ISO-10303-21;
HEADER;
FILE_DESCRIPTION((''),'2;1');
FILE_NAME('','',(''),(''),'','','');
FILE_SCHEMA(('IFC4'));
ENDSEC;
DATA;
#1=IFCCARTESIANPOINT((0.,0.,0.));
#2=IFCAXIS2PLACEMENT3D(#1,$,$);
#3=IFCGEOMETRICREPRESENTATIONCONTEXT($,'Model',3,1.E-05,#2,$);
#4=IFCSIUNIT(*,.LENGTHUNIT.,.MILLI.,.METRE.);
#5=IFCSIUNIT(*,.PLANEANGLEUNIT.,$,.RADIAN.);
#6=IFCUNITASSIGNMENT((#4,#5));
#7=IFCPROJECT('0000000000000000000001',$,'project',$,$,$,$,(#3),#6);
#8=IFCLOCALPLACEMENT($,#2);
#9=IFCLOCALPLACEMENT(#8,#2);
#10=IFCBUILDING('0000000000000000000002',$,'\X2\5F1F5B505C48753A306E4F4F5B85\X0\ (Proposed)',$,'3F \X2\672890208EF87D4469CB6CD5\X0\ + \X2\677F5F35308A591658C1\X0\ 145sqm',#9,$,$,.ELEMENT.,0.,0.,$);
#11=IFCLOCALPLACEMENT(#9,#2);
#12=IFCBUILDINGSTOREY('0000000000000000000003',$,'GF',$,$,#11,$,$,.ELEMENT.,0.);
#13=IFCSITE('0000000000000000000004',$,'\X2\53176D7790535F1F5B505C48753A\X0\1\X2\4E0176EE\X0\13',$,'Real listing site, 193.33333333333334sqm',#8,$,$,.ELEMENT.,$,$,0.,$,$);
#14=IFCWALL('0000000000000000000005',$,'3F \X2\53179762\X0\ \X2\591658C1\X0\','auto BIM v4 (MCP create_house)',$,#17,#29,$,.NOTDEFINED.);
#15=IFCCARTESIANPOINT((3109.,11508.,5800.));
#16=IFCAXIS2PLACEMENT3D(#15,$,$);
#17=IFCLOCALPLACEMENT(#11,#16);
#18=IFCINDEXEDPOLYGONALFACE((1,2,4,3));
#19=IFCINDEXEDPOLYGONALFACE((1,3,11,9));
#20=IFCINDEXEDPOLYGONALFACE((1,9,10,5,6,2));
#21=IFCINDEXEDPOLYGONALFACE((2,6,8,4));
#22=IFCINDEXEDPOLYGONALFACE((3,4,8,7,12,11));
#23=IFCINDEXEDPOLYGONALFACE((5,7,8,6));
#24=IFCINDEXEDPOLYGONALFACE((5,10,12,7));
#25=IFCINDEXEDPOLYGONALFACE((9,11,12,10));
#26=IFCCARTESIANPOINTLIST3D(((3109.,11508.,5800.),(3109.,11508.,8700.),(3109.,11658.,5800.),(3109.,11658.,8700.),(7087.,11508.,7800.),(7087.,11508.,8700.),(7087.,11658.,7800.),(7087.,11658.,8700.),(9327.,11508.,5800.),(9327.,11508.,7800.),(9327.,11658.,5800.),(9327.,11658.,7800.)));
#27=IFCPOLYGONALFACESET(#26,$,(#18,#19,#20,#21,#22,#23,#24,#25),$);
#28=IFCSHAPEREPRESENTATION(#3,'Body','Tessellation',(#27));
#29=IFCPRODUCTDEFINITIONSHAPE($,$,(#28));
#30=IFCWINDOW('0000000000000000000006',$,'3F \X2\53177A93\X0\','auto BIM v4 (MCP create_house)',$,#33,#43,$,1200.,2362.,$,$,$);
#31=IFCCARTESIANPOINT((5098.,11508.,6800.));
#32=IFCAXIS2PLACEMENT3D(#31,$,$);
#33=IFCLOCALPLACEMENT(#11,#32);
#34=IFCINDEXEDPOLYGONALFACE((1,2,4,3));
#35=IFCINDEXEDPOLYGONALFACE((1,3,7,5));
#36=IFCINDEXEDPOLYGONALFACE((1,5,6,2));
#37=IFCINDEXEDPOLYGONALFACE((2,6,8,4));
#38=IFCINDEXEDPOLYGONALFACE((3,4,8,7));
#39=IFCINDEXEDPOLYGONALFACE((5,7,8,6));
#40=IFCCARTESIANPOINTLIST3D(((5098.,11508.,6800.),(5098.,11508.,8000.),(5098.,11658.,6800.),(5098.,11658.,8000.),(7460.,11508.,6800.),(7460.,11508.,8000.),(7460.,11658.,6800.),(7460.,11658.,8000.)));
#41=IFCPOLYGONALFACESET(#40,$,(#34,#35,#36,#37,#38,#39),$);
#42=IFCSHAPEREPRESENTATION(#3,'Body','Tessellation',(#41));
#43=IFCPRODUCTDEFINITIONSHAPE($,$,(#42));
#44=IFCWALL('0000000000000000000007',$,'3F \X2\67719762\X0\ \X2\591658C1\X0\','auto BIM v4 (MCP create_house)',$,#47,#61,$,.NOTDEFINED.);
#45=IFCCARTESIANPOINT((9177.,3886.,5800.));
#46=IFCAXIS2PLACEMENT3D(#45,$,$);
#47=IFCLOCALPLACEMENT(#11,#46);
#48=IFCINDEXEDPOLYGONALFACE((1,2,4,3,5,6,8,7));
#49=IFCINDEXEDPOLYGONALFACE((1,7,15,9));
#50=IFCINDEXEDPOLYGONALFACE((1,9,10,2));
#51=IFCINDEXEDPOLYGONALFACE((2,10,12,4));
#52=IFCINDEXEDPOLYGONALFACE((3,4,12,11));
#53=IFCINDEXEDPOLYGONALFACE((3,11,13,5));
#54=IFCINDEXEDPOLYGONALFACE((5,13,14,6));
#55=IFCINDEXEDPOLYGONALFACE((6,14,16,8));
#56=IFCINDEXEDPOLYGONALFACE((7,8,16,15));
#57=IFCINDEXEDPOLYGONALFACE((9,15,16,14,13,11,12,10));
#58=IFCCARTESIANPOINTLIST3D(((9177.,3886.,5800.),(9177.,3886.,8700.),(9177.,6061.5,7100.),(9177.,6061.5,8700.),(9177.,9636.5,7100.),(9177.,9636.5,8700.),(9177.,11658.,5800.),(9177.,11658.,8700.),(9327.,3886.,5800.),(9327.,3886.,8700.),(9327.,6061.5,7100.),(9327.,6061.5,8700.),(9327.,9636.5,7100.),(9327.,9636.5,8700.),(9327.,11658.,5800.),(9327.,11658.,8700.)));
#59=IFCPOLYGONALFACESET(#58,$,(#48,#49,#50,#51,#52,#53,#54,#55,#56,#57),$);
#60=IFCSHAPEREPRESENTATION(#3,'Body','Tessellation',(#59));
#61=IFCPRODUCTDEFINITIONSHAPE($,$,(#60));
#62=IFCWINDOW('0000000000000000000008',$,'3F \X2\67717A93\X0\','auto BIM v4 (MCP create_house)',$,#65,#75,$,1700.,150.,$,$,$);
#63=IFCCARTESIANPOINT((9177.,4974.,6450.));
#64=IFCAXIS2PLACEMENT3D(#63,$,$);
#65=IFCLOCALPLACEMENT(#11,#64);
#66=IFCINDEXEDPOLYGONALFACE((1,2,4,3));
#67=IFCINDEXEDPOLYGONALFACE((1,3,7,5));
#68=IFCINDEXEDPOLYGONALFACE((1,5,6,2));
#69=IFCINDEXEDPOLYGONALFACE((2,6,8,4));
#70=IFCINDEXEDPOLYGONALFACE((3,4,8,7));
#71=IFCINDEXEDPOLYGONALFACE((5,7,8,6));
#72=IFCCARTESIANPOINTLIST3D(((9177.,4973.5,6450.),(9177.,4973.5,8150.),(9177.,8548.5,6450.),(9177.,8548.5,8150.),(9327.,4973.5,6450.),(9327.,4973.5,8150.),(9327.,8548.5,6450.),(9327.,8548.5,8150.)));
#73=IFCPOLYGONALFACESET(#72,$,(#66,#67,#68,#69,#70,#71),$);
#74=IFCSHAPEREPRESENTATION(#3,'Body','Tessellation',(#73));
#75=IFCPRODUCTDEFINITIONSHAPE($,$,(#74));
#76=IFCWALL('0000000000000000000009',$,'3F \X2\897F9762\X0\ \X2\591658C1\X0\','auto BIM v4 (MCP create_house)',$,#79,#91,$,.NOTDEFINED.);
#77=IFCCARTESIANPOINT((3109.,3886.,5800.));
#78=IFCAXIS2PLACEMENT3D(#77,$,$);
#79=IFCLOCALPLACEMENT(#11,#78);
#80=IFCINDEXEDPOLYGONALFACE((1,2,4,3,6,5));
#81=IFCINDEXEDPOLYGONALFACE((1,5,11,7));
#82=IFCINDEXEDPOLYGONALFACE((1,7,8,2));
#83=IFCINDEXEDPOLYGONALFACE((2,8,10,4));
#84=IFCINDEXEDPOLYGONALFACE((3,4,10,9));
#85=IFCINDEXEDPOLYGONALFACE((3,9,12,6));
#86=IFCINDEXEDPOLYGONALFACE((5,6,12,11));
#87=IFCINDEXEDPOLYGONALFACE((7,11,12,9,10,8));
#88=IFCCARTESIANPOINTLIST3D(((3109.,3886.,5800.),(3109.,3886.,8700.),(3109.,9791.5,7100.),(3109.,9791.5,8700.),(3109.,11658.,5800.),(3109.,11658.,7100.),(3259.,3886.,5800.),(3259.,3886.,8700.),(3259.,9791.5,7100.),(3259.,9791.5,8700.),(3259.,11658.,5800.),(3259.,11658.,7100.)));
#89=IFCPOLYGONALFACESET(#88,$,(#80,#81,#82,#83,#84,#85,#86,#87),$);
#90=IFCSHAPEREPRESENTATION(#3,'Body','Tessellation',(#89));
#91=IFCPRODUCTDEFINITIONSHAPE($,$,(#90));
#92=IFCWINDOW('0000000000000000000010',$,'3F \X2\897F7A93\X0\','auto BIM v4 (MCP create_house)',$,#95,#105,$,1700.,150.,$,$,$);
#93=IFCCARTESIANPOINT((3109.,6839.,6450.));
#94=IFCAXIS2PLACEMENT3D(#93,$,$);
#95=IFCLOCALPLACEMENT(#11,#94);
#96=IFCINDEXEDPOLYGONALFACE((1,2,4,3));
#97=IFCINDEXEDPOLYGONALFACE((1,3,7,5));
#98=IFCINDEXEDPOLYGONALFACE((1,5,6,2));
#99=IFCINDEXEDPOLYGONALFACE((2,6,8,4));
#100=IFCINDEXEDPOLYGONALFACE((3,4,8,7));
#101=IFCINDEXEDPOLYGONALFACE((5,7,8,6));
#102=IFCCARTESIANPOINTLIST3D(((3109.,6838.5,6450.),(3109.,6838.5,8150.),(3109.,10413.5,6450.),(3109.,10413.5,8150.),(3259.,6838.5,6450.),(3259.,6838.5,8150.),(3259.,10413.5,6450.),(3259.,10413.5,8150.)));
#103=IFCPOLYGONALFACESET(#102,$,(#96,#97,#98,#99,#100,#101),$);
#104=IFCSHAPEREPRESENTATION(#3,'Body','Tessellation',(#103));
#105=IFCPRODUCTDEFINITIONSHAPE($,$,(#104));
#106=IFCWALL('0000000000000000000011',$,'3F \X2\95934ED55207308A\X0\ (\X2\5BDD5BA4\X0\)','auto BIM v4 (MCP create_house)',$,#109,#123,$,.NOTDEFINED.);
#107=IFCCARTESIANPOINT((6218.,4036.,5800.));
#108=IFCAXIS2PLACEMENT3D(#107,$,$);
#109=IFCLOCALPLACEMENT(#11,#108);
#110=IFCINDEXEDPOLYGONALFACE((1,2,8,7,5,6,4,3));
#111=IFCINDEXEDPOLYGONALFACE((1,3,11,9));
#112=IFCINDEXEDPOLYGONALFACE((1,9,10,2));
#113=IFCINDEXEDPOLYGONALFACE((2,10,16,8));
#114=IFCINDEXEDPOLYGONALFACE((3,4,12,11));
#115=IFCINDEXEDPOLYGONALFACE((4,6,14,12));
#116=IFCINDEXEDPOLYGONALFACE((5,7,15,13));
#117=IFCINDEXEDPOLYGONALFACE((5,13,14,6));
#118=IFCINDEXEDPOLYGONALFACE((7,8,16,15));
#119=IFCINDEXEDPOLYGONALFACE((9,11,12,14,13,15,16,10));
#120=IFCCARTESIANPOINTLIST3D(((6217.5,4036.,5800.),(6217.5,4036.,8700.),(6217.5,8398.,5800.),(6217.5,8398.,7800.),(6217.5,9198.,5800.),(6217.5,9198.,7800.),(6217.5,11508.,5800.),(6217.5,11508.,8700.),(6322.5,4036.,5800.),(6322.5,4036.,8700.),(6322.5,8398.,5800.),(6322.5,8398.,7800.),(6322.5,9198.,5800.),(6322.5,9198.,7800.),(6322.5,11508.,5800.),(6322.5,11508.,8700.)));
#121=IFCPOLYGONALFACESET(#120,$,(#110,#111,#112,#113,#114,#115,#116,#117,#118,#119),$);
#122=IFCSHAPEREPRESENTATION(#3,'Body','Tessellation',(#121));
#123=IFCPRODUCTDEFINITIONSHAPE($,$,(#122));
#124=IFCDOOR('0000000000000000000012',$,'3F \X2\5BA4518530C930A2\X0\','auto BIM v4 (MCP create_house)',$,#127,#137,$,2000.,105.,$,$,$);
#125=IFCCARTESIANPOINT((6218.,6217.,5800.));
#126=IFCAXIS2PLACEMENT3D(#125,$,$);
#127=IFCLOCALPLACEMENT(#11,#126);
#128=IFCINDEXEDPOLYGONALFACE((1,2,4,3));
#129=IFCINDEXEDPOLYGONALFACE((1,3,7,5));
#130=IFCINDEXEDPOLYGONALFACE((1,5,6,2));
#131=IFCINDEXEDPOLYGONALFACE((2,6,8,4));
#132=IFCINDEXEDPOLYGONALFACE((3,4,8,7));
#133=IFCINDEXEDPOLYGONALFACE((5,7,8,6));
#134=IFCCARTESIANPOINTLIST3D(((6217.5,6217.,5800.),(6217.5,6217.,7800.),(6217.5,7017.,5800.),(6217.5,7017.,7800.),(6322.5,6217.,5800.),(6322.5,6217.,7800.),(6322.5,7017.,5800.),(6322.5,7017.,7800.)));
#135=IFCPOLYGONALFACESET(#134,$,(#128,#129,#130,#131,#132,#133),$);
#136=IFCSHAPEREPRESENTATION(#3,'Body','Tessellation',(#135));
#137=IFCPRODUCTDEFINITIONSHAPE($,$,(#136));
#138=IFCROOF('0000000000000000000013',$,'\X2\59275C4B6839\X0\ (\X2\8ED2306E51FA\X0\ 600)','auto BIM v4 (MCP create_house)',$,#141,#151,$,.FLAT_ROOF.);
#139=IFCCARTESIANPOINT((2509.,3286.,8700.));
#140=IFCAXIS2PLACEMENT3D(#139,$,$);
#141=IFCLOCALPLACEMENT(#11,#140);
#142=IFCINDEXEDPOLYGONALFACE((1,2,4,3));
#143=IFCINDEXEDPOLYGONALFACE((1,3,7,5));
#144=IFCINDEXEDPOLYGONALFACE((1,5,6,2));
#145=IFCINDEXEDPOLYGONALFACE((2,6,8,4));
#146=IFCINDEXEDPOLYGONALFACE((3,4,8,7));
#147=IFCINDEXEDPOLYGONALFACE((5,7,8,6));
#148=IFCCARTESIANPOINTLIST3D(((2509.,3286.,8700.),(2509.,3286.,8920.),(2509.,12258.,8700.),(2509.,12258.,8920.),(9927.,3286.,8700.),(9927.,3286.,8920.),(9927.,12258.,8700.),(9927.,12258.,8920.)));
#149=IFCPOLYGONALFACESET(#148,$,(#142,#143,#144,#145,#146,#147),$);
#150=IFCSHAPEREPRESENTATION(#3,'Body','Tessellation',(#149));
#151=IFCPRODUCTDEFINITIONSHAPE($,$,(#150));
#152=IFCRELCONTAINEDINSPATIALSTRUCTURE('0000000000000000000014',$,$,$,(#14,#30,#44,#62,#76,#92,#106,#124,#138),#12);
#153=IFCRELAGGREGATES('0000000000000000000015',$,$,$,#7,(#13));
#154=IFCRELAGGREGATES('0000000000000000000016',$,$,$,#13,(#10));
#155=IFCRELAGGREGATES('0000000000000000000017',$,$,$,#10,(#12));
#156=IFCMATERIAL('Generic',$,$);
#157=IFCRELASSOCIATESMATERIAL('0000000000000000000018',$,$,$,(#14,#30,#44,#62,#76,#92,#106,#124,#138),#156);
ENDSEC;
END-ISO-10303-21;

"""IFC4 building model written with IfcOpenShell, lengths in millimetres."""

from ifc_helpers import new_model, si_unit, frame, frame_2d, origin, place, context, project, spatial, rectangle, extrude, material, element, fill, save


model = new_model("IFC4")

# Units and contexts
model_context = context("Model", 3, precision=1e-05, world=origin())
ifc_project = project(units=[si_unit("LENGTHUNIT", "METRE", prefix="MILLI"), si_unit("PLANEANGLEUNIT", "RADIAN")], contexts=[model_context])

# Site, building, storey
site_placement = place(None, origin())
site = spatial("IfcSite", under=ifc_project, at=site_placement, Name="北海道弟子屈町1丁目13", ObjectType="Real listing site, 193.33333333333334sqm", CompositionType="ELEMENT", RefElevation=0.0)
building_placement = place(site_placement, origin())
building = spatial("IfcBuilding", under=site, at=building_placement, Name="弟子屈町の住宅 (Proposed)", ObjectType="3F 木造軸組構法 + 板張り外壁 145sqm", CompositionType="ELEMENT", ElevationOfRefHeight=0.0, ElevationOfTerrain=0.0)
storey_placement = place(building_placement, origin())
storey = spatial("IfcBuildingStorey", under=building, at=storey_placement, Name="GF", CompositionType="ELEMENT", Elevation=0.0)

# Shared definitions
ifc_material = material(Name="Generic")

# Walls, openings, windows
wall_1_placement = place(storey_placement, frame((3109.0, 11508.0, 5800.0)))
wall_1 = element("IfcWall", 1, at=wall_1_placement, inside=storey, material=ifc_material, Name="3F 北面 外壁", Description="auto BIM v4 (MCP create_house)", PredefinedType="NOTDEFINED", context=model_context, shape_type="SweptSolid", body=[
    extrude(rectangle(XDim=6218.0, YDim=150.0, at=frame_2d((3109.0, 75.0))), frame((3109.0, 11508.0, 5800.0)), (0.0, 0.0, 1.0), 2900.0),
])
opening_1_placement = place(storey_placement, frame((5098.0, 11508.0, 6800.0)))
opening_1 = element("IfcOpeningElement", 2, at=opening_1_placement, cuts=wall_1, PredefinedType="NOTDEFINED", context=model_context, shape_type="SweptSolid", body=[
    extrude(rectangle(XDim=2362.0, YDim=150.0, at=frame_2d((1181.0, 75.0))), frame((5098.0, 11508.0, 6800.0)), (0.0, 0.0, 1.0), 1200.0),
])
window_1_placement = place(storey_placement, frame((5098.0, 11508.0, 6800.0)))
window_1 = element("IfcWindow", 3, at=window_1_placement, inside=storey, material=ifc_material, Name="3F 北窓", Description="auto BIM v4 (MCP create_house)", OverallHeight=1200.0, OverallWidth=2362.0, context=model_context, shape_type="SweptSolid", body=[
    extrude(rectangle(XDim=2362.0, YDim=150.0, at=frame_2d((1181.0, 75.0))), frame((5098.0, 11508.0, 6800.0)), (0.0, 0.0, 1.0), 1200.0),
])
fill(opening_1, window_1)
wall_2_placement = place(storey_placement, frame((9177.0, 3886.0, 5800.0)))
wall_2 = element("IfcWall", 4, at=wall_2_placement, inside=storey, material=ifc_material, Name="3F 東面 外壁", Description="auto BIM v4 (MCP create_house)", PredefinedType="NOTDEFINED", context=model_context, shape_type="SweptSolid", body=[
    extrude(rectangle(XDim=150.0, YDim=7772.0, at=frame_2d((75.0, 3886.0))), frame((9177.0, 3886.0, 5800.0)), (0.0, 0.0, 1.0), 2900.0),
])
opening_2_placement = place(storey_placement, frame((9177.0, 4974.0, 6450.0)))
opening_2 = element("IfcOpeningElement", 5, at=opening_2_placement, cuts=wall_2, PredefinedType="NOTDEFINED", context=model_context, shape_type="SweptSolid", body=[
    extrude(rectangle(XDim=150.0, YDim=3575.0, at=frame_2d((75.0, 1787.0))), frame((9177.0, 4974.0, 6450.0)), (0.0, 0.0, 1.0), 1700.0),
])
window_2_placement = place(storey_placement, frame((9177.0, 4974.0, 6450.0)))
window_2 = element("IfcWindow", 6, at=window_2_placement, inside=storey, material=ifc_material, Name="3F 東窓", Description="auto BIM v4 (MCP create_house)", OverallHeight=1700.0, OverallWidth=150.0, context=model_context, shape_type="SweptSolid", body=[
    extrude(rectangle(XDim=150.0, YDim=3575.0, at=frame_2d((75.0, 1787.0))), frame((9177.0, 4974.0, 6450.0)), (0.0, 0.0, 1.0), 1700.0),
])
fill(opening_2, window_2)
wall_3_placement = place(storey_placement, frame((3109.0, 3886.0, 5800.0)))
wall_3 = element("IfcWall", 7, at=wall_3_placement, inside=storey, material=ifc_material, Name="3F 西面 外壁", Description="auto BIM v4 (MCP create_house)", PredefinedType="NOTDEFINED", context=model_context, shape_type="SweptSolid", body=[
    extrude(rectangle(XDim=150.0, YDim=7772.0, at=frame_2d((75.0, 3886.0))), frame((3109.0, 3886.0, 5800.0)), (0.0, 0.0, 1.0), 2900.0),
])
opening_3_placement = place(storey_placement, frame((3109.0, 6839.0, 6450.0)))
opening_3 = element("IfcOpeningElement", 8, at=opening_3_placement, cuts=wall_3, PredefinedType="NOTDEFINED", context=model_context, shape_type="SweptSolid", body=[
    extrude(rectangle(XDim=150.0, YDim=3575.0, at=frame_2d((75.0, 1787.0))), frame((3109.0, 6839.0, 6450.0)), (0.0, 0.0, 1.0), 1700.0),
])
window_3_placement = place(storey_placement, frame((3109.0, 6839.0, 6450.0)))
window_3 = element("IfcWindow", 9, at=window_3_placement, inside=storey, material=ifc_material, Name="3F 西窓", Description="auto BIM v4 (MCP create_house)", OverallHeight=1700.0, OverallWidth=150.0, context=model_context, shape_type="SweptSolid", body=[
    extrude(rectangle(XDim=150.0, YDim=3575.0, at=frame_2d((75.0, 1787.0))), frame((3109.0, 6839.0, 6450.0)), (0.0, 0.0, 1.0), 1700.0),
])
fill(opening_3, window_3)

# Wall, opening, door
wall_4_placement = place(storey_placement, frame((6218.0, 4036.0, 5800.0)))
wall_4 = element("IfcWall", 10, at=wall_4_placement, inside=storey, material=ifc_material, Name="3F 間仕切り (寝室)", Description="auto BIM v4 (MCP create_house)", PredefinedType="NOTDEFINED", context=model_context, shape_type="SweptSolid", body=[
    extrude(rectangle(XDim=105.0, YDim=7472.0, at=frame_2d((52.0, 3736.0))), frame((6218.0, 4036.0, 5800.0)), (0.0, 0.0, 1.0), 2900.0),
])
opening_4_placement = place(storey_placement, frame((6218.0, 6217.0, 5800.0)))
opening_4 = element("IfcOpeningElement", 11, at=opening_4_placement, cuts=wall_4, PredefinedType="NOTDEFINED", context=model_context, shape_type="SweptSolid", body=[
    extrude(rectangle(XDim=105.0, YDim=800.0, at=frame_2d((52.0, 400.0))), frame((6218.0, 6217.0, 5800.0)), (0.0, 0.0, 1.0), 2000.0),
])
door_1_placement = place(storey_placement, frame((6218.0, 6217.0, 5800.0)))
door_1 = element("IfcDoor", 12, at=door_1_placement, inside=storey, material=ifc_material, Name="3F 室内ドア", Description="auto BIM v4 (MCP create_house)", OverallHeight=2000.0, OverallWidth=105.0, context=model_context, shape_type="SweptSolid", body=[
    extrude(rectangle(XDim=105.0, YDim=800.0, at=frame_2d((52.0, 400.0))), frame((6218.0, 6217.0, 5800.0)), (0.0, 0.0, 1.0), 2000.0),
])
fill(opening_4, door_1)

# Roof
roof_placement = place(storey_placement, frame((2509.0, 3286.0, 8700.0)))
element("IfcRoof", 13, at=roof_placement, inside=storey, material=ifc_material, Name="大屋根 (軒の出 600)", Description="auto BIM v4 (MCP create_house)", PredefinedType="FLAT_ROOF", context=model_context, shape_type="SweptSolid", body=[
    extrude(rectangle(XDim=7418.0, YDim=8972.0, at=frame_2d((3709.0, 4486.0))), frame((2509.0, 3286.0, 8700.0)), (0.0, 0.0, 1.0), 220.0),
])

save(model, "model.ifc")
